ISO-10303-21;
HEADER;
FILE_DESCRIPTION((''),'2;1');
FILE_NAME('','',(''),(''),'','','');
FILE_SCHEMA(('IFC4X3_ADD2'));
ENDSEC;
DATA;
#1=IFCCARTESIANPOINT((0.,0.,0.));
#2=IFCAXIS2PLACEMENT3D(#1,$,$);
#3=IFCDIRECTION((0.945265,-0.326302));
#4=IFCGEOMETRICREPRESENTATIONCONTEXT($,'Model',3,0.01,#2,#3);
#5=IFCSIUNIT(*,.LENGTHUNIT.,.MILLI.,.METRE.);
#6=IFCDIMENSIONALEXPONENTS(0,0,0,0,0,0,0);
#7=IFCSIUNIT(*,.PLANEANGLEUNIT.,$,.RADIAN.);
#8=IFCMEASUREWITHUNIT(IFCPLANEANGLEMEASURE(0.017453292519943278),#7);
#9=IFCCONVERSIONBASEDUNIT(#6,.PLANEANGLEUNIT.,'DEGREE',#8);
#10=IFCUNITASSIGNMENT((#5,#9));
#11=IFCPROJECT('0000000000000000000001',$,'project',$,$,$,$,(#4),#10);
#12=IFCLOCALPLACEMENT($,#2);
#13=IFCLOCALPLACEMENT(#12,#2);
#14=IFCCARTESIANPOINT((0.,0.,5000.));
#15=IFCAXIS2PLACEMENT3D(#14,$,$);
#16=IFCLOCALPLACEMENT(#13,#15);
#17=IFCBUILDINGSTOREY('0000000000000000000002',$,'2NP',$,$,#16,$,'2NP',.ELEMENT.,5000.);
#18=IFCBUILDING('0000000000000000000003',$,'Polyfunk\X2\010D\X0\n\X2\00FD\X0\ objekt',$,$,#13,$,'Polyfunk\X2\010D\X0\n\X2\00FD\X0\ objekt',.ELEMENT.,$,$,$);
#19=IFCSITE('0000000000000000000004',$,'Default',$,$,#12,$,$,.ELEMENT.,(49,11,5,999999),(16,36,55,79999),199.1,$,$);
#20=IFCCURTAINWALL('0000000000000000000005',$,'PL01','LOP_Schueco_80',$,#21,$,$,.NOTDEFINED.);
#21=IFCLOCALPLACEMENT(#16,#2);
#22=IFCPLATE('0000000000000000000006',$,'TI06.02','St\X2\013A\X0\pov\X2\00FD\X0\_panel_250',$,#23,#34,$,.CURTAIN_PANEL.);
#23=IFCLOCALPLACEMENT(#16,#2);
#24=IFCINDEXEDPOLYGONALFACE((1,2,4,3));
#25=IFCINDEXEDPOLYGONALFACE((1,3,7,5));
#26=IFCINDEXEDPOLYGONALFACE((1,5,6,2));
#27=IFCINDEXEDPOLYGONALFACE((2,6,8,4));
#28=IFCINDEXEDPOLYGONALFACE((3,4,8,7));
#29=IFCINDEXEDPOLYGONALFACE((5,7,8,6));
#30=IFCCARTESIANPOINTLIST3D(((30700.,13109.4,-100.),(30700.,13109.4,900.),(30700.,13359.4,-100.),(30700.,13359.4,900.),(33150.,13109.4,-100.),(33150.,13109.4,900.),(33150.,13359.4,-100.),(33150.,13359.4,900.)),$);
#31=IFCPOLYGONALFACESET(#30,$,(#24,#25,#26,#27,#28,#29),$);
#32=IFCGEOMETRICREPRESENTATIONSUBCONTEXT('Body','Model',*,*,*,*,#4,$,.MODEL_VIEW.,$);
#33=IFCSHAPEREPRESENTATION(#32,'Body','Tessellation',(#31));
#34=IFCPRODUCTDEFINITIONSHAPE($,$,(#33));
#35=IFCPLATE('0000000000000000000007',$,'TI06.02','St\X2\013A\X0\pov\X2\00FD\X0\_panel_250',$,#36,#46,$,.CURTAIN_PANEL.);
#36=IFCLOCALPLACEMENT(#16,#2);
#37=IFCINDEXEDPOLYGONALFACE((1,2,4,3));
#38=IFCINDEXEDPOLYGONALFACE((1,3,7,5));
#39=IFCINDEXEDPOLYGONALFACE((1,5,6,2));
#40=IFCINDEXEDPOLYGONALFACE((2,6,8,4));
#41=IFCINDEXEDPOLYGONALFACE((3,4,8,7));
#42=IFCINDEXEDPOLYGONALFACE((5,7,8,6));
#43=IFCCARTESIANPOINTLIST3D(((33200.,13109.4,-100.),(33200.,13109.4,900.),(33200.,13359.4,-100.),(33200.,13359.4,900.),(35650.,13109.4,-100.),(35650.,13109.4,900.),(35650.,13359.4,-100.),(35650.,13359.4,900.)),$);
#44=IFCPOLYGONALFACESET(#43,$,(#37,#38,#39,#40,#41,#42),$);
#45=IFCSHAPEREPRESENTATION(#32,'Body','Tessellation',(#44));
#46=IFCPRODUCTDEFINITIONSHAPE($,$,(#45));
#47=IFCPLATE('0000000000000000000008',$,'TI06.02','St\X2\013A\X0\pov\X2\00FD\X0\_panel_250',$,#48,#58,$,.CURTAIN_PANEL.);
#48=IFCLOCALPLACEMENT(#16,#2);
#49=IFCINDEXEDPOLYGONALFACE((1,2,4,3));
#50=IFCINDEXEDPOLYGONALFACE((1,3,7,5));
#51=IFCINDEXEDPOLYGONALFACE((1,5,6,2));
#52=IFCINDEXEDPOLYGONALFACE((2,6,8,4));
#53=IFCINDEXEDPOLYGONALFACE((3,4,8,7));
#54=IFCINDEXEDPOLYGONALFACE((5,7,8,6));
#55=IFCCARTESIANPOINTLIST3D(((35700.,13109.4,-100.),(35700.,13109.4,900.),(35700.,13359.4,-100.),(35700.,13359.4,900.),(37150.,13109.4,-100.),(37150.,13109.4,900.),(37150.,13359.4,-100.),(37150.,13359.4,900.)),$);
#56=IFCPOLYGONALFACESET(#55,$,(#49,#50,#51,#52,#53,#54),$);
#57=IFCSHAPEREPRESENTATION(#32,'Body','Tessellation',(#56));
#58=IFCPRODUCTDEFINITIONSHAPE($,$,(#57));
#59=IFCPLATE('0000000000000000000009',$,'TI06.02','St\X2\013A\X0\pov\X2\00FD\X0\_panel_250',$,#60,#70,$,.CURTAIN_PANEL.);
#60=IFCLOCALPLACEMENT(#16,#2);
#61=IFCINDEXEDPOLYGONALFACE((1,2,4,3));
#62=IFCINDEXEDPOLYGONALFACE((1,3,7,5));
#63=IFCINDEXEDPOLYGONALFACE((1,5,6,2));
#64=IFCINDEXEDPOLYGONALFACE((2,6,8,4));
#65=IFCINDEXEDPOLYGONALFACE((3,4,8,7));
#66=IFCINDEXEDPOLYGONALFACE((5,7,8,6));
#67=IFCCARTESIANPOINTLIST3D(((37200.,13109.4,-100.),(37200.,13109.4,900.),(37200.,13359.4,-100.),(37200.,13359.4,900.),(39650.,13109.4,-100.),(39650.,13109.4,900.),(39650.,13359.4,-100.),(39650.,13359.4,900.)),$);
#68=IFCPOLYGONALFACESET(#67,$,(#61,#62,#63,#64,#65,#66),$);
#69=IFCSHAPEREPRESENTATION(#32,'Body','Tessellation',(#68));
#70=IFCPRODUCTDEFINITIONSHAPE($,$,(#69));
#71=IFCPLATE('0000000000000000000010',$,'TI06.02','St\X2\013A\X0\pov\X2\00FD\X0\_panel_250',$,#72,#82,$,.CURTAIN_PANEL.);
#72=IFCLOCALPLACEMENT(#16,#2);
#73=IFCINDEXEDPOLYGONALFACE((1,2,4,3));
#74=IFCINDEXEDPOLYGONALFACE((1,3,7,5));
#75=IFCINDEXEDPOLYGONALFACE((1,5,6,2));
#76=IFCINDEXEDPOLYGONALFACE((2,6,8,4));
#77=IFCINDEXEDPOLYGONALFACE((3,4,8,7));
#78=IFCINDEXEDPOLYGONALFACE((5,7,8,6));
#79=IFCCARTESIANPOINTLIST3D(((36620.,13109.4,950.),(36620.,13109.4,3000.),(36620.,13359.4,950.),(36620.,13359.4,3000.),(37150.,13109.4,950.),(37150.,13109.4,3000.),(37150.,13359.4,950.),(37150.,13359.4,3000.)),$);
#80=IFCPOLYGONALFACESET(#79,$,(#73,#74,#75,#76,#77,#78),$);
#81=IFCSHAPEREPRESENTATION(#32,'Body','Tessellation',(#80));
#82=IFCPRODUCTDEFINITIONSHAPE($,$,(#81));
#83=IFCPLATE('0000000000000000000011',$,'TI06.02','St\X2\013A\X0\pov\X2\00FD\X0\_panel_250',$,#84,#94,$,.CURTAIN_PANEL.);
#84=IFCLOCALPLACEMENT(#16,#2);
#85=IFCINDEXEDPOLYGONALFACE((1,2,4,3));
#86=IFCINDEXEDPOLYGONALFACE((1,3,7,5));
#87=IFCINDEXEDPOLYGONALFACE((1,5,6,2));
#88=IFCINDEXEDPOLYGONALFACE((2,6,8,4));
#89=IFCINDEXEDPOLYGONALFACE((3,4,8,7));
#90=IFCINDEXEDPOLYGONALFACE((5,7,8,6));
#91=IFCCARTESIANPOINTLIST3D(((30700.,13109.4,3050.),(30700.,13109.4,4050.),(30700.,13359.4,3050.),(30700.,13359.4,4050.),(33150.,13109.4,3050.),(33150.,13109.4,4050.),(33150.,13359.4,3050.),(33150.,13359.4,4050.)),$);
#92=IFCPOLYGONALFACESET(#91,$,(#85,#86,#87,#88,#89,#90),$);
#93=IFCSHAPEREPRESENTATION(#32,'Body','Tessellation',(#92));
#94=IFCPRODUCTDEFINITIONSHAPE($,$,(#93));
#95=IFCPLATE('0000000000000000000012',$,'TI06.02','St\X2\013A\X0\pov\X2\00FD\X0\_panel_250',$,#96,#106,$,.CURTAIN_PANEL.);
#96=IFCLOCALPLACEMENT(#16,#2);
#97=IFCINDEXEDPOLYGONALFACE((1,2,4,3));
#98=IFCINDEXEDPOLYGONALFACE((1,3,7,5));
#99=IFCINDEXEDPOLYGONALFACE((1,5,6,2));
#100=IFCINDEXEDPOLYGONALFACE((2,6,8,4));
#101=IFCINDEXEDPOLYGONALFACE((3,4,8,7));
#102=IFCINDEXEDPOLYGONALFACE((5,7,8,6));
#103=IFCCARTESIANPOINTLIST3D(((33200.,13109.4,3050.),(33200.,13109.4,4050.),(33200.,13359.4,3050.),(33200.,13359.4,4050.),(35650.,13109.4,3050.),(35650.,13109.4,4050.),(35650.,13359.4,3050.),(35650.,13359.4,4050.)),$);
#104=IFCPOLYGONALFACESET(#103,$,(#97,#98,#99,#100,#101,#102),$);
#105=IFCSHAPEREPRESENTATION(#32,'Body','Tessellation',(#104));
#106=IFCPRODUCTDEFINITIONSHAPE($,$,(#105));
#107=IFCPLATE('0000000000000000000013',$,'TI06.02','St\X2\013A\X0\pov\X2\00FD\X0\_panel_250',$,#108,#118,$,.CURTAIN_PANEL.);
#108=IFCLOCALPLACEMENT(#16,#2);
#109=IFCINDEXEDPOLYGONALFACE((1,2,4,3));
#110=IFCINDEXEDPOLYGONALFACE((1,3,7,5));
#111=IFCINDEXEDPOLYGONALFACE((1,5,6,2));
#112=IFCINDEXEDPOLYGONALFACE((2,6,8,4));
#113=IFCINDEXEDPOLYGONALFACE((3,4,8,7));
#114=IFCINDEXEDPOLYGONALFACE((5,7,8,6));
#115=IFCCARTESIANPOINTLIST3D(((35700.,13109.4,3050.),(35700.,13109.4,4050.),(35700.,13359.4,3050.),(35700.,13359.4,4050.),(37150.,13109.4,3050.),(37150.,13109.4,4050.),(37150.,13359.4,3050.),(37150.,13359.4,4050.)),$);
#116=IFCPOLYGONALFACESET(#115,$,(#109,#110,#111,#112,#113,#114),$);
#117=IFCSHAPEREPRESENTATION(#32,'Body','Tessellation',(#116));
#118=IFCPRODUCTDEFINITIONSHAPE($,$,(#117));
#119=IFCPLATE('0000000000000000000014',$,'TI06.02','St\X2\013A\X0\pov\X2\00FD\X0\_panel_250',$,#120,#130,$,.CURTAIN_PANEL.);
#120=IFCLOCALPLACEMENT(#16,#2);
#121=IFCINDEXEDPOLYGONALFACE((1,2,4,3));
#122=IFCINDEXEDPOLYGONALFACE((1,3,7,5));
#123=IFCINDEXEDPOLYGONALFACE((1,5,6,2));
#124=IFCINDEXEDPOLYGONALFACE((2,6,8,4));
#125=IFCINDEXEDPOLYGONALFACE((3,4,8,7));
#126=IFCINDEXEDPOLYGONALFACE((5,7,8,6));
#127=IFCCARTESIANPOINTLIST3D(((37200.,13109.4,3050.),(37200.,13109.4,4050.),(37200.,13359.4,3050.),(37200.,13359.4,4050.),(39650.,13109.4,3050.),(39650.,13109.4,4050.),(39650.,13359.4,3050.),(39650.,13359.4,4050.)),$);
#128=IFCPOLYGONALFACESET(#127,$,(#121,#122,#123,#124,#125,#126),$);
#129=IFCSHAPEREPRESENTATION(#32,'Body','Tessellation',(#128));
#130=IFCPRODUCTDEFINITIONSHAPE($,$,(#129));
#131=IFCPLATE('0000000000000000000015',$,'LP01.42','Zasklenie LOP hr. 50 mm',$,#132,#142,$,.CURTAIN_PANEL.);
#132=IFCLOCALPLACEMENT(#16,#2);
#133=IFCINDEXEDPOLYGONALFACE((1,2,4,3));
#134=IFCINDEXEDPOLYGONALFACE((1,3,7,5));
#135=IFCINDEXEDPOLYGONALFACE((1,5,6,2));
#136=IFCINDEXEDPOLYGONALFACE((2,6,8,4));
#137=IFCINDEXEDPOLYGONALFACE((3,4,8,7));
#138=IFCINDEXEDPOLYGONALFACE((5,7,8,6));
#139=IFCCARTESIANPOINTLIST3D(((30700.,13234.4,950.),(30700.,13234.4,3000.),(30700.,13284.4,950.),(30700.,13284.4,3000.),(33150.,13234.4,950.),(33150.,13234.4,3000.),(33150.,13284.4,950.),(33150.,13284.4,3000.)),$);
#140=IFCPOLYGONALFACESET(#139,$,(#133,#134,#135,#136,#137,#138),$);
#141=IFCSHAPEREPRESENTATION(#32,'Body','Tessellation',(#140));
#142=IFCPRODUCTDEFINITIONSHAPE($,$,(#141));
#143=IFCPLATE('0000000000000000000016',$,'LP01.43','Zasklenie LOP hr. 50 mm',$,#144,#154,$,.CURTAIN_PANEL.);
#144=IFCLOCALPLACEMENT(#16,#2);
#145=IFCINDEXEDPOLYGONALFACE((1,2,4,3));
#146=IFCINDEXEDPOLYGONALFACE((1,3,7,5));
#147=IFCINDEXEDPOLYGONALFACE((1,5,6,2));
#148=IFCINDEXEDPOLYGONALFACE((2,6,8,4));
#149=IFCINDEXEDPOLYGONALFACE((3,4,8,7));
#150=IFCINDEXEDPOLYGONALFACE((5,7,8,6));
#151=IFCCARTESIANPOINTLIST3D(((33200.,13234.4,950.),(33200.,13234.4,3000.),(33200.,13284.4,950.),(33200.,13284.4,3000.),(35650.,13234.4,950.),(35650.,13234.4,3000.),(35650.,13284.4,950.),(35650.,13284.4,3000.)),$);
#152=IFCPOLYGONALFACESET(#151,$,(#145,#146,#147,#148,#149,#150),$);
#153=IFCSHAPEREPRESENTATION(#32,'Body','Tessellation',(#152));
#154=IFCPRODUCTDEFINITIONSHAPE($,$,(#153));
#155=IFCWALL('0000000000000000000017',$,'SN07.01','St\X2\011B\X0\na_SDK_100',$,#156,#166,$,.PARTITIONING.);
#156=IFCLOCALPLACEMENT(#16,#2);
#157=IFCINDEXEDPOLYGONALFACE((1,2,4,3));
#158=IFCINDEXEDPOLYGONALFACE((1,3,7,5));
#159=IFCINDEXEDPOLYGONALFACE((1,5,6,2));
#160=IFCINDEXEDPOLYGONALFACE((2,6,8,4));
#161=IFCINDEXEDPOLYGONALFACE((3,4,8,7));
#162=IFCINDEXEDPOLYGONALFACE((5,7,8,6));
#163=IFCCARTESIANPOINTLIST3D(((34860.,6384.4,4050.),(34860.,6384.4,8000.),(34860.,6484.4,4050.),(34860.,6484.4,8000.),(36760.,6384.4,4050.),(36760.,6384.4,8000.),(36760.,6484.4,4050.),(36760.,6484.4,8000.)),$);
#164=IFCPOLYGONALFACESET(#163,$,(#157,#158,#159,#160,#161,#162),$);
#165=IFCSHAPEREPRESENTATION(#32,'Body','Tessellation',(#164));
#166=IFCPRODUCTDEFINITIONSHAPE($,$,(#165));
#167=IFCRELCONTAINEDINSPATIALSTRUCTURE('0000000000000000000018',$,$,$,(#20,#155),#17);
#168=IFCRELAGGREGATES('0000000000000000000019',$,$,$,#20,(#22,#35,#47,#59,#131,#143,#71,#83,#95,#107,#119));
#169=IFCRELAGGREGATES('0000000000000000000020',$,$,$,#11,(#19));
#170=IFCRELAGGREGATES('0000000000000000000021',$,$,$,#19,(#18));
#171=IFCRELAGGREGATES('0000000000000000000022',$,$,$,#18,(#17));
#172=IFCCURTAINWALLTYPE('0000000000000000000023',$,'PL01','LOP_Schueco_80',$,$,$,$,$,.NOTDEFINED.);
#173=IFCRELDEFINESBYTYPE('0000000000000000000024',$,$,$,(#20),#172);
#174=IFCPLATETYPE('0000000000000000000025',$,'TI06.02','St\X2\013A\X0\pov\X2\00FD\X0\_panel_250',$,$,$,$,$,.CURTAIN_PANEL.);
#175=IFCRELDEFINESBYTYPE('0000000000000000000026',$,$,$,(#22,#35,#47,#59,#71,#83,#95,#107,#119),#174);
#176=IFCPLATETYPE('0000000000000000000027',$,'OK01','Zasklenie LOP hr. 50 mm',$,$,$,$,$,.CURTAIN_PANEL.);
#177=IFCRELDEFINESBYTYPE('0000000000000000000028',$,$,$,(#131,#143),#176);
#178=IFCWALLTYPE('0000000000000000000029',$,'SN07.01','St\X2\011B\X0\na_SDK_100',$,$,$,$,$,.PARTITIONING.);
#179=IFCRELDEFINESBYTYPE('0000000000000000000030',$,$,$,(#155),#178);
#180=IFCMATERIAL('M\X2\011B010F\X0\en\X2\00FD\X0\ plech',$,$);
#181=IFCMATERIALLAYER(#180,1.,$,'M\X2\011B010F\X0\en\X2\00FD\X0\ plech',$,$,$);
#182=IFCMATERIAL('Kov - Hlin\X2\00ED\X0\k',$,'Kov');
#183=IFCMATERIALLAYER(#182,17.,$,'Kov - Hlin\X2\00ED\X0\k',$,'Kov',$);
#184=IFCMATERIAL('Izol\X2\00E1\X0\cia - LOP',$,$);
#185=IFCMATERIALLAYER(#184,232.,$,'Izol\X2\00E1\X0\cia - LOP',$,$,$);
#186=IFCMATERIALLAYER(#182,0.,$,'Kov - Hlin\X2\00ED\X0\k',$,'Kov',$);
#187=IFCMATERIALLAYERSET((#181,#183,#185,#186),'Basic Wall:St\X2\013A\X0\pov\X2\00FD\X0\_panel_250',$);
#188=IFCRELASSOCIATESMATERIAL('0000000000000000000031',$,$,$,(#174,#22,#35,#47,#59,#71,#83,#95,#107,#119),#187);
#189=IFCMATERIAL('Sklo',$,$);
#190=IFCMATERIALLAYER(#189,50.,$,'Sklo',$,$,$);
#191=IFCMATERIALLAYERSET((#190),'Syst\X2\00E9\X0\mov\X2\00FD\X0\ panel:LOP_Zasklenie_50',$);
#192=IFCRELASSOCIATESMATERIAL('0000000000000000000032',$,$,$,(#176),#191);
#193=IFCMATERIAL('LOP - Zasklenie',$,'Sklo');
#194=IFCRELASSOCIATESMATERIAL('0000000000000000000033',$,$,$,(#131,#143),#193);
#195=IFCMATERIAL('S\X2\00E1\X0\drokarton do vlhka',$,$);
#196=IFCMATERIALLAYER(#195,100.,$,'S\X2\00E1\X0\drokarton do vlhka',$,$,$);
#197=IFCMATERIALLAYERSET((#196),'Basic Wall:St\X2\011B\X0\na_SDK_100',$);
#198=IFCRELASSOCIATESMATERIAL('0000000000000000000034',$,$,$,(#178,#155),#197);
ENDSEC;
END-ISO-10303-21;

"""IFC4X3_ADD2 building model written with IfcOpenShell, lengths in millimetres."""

from ifc_helpers import new_model, entity, si_unit, converted_unit, direction, frame, frame_2d, origin, origin_2d_with_axis, place, context, subcontext, project, spatial, polyline, rectangle, extrude, clip, bounded_halfspace, source, transform, mapped, material, layer, layer_set, layer_usage, type_object, type_shapes, element, aggregate, save


model = new_model("IFC4X3_ADD2")

# Units and contexts
model_context = context("Model", 3, precision=0.01, world=origin(), true_north=direction((0.945265, -0.326302)))
body_context = subcontext(model_context, "Body", "Model", "MODEL_VIEW")
ifc_project = project(units=[si_unit("LENGTHUNIT", "METRE", prefix="MILLI"), converted_unit("PLANEANGLEUNIT", "DEGREE", entity("IfcPlaneAngleMeasure", 0.017453292519943278), si_unit("PLANEANGLEUNIT", "RADIAN"), dimensions=[0, 0, 0, 0, 0, 0, 0])], contexts=[model_context])

# Site, building, storey
site_placement = place(None, origin())
site = spatial("IfcSite", under=ifc_project, at=site_placement, Name="Default", CompositionType="ELEMENT", RefLatitude=(49, 11, 5, 999999), RefLongitude=(16, 36, 55, 79999), RefElevation=199.1)
building_placement = place(site_placement, origin())
building = spatial("IfcBuilding", under=site, at=building_placement, Name="Polyfunkčný objekt", LongName="Polyfunkčný objekt", CompositionType="ELEMENT")
storey_placement = place(building_placement, frame((0.0, 0.0, 5000.0)))
storey = spatial("IfcBuildingStorey", under=building, at=storey_placement, Name="2NP", LongName="2NP", CompositionType="ELEMENT", Elevation=5000.0)

# Curtain wall, plates
curtain_wall_type = type_object("IfcCurtainWallType", Name="PL01", Description="LOP_Schueco_80", PredefinedType="NOTDEFINED")
curtain_wall_placement = place(storey_placement, frame((0.0, 0.0, -5000.0)))
curtain_wall = element("IfcCurtainWall", 1, at=curtain_wall_placement, inside=storey, type_object=curtain_wall_type, Name="PL01", Description="LOP_Schueco_80", PredefinedType="NOTDEFINED")
ifc_material_1 = material(Name="Měďený plech")
ifc_layer_1 = layer(ifc_material_1, 1.0, Name="Měďený plech")
ifc_material_2 = material(Name="Kov - Hliník", Category="Kov")
ifc_layer_2 = layer(ifc_material_2, 17.0, Name="Kov - Hliník", Category="Kov")
ifc_material_3 = material(Name="Izolácia - LOP")
ifc_layer_3 = layer(ifc_material_3, 232.0, Name="Izolácia - LOP")
ifc_layer_4 = layer(ifc_material_2, 0.0, Name="Kov - Hliník", Category="Kov")
ifc_layer_set_1 = layer_set([ifc_layer_1, ifc_layer_2, ifc_layer_3, ifc_layer_4], Name="Basic Wall:Stĺpový_panel_250")
ifc_layer_usage_1 = layer_usage(ifc_layer_set_1, "AXIS2", "NEGATIVE", 125.0)
plate_type_1 = type_object("IfcPlateType", Name="TI06.02", Description="Stĺpový_panel_250", PredefinedType="CURTAIN_PANEL", material=ifc_layer_set_1)
plate_1_placement = place(storey_placement, frame((30700.0, 13234.4, -100.0)))
plate_1 = element("IfcPlate", 2, at=plate_1_placement, type_object=plate_type_1, material=ifc_layer_usage_1, Name="TI06.02", Description="Stĺpový_panel_250", PredefinedType="CURTAIN_PANEL", context=body_context, shape_type="SweptSolid", body=[
    extrude(rectangle(XDim=250.0, YDim=2450.0, at=frame_2d((0.0, 0.0), x_axis=(1.0, 0.0))), frame((1225.0, 0.0, 0.0), z_axis=(0.0, 0.0, 1.0), x_axis=(0.0, 1.0, 0.0)), (0.0, 0.0, 1.0), 1000.0),
])
ifc_layer_usage_2 = layer_usage(ifc_layer_set_1, "AXIS2", "NEGATIVE", 125.0)
plate_2_placement = place(storey_placement, frame((33200.0, 13234.4, -100.0)))
plate_2 = element("IfcPlate", 3, at=plate_2_placement, type_object=plate_type_1, material=ifc_layer_usage_2, Name="TI06.02", Description="Stĺpový_panel_250", PredefinedType="CURTAIN_PANEL", context=body_context, shape_type="SweptSolid", body=[
    extrude(rectangle(XDim=250.0, YDim=2450.0, at=frame_2d((0.0, 0.0), x_axis=(1.0, 0.0))), frame((1225.0, 0.0, 0.0), z_axis=(0.0, 0.0, 1.0), x_axis=(0.0, 1.0, 0.0)), (0.0, 0.0, 1.0), 1000.0),
])
ifc_layer_usage_3 = layer_usage(ifc_layer_set_1, "AXIS2", "NEGATIVE", 125.0)
plate_3_placement = place(storey_placement, frame((35700.0, 13234.4, -100.0)))
plate_3 = element("IfcPlate", 4, at=plate_3_placement, type_object=plate_type_1, material=ifc_layer_usage_3, Name="TI06.02", Description="Stĺpový_panel_250", PredefinedType="CURTAIN_PANEL", context=body_context, shape_type="SweptSolid", body=[
    extrude(rectangle(XDim=250.0, YDim=1450.0, at=origin_2d_with_axis()), frame((725.0, 0.0, 0.0), z_axis=(0.0, 0.0, 1.0), x_axis=(0.0, 1.0, 0.0)), (0.0, 0.0, 1.0), 1000.0),
])
ifc_layer_usage_4 = layer_usage(ifc_layer_set_1, "AXIS2", "NEGATIVE", 125.0)
plate_4_placement = place(storey_placement, frame((37200.0, 13234.4, -100.0)))
plate_4 = element("IfcPlate", 5, at=plate_4_placement, type_object=plate_type_1, material=ifc_layer_usage_4, Name="TI06.02", Description="Stĺpový_panel_250", PredefinedType="CURTAIN_PANEL", context=body_context, shape_type="SweptSolid", body=[
    extrude(rectangle(XDim=250.0, YDim=2450.0, at=frame_2d((0.0, 0.0), x_axis=(1.0, 0.0))), frame((1225.0, 0.0, 0.0), z_axis=(0.0, 0.0, 1.0), x_axis=(0.0, 1.0, 0.0)), (0.0, 0.0, 1.0), 1000.0),
])
ifc_layer_usage_5 = layer_usage(ifc_layer_set_1, "AXIS2", "NEGATIVE", 125.0)
plate_5_placement = place(storey_placement, frame((36620.0, 13234.4, 950.0)))
plate_5 = element("IfcPlate", 6, at=plate_5_placement, type_object=plate_type_1, material=ifc_layer_usage_5, Name="TI06.02", Description="Stĺpový_panel_250", PredefinedType="CURTAIN_PANEL", context=body_context, shape_type="SweptSolid", body=[
    extrude(rectangle(XDim=250.0, YDim=530.0, at=frame_2d((0.0, 0.0), x_axis=(1.0, 0.0))), frame((265.0, 0.0, 0.0), z_axis=(0.0, 0.0, 1.0), x_axis=(0.0, 1.0, 0.0)), (0.0, 0.0, 1.0), 2050.0),
])
ifc_layer_usage_6 = layer_usage(ifc_layer_set_1, "AXIS2", "NEGATIVE", 125.0)
plate_6_placement = place(storey_placement, frame((30700.0, 13234.4, 3050.0)))
plate_6 = element("IfcPlate", 7, at=plate_6_placement, type_object=plate_type_1, material=ifc_layer_usage_6, Name="TI06.02", Description="Stĺpový_panel_250", PredefinedType="CURTAIN_PANEL", context=body_context, shape_type="SweptSolid", body=[
    extrude(rectangle(XDim=250.0, YDim=2450.0, at=frame_2d((0.0, 0.0), x_axis=(1.0, 0.0))), frame((1225.0, 0.0, 0.0), z_axis=(0.0, 0.0, 1.0), x_axis=(0.0, 1.0, 0.0)), (0.0, 0.0, 1.0), 1000.0),
])
ifc_layer_usage_7 = layer_usage(ifc_layer_set_1, "AXIS2", "NEGATIVE", 125.0)
plate_7_placement = place(storey_placement, frame((33200.0, 13234.4, 3050.0)))
plate_7 = element("IfcPlate", 8, at=plate_7_placement, type_object=plate_type_1, material=ifc_layer_usage_7, Name="TI06.02", Description="Stĺpový_panel_250", PredefinedType="CURTAIN_PANEL", context=body_context, shape_type="SweptSolid", body=[
    extrude(rectangle(XDim=250.0, YDim=2450.0, at=frame_2d((0.0, 0.0), x_axis=(1.0, 0.0))), frame((1225.0, 0.0, 0.0), z_axis=(0.0, 0.0, 1.0), x_axis=(0.0, 1.0, 0.0)), (0.0, 0.0, 1.0), 1000.0),
])
ifc_layer_usage_8 = layer_usage(ifc_layer_set_1, "AXIS2", "NEGATIVE", 125.0)
plate_8_placement = place(storey_placement, frame((35700.0, 13234.4, 3050.0)))
plate_8 = element("IfcPlate", 9, at=plate_8_placement, type_object=plate_type_1, material=ifc_layer_usage_8, Name="TI06.02", Description="Stĺpový_panel_250", PredefinedType="CURTAIN_PANEL", context=body_context, shape_type="SweptSolid", body=[
    extrude(rectangle(XDim=250.0, YDim=1450.0, at=origin_2d_with_axis()), frame((725.0, 0.0, 0.0), z_axis=(0.0, 0.0, 1.0), x_axis=(0.0, 1.0, 0.0)), (0.0, 0.0, 1.0), 1000.0),
])
ifc_layer_usage_9 = layer_usage(ifc_layer_set_1, "AXIS2", "NEGATIVE", 125.0)
plate_9_placement = place(storey_placement, frame((37200.0, 13234.4, 3050.0)))
plate_9 = element("IfcPlate", 10, at=plate_9_placement, type_object=plate_type_1, material=ifc_layer_usage_9, Name="TI06.02", Description="Stĺpový_panel_250", PredefinedType="CURTAIN_PANEL", context=body_context, shape_type="SweptSolid", body=[
    extrude(rectangle(XDim=250.0, YDim=2450.0, at=frame_2d((0.0, 0.0), x_axis=(1.0, 0.0))), frame((1225.0, 0.0, 0.0), z_axis=(0.0, 0.0, 1.0), x_axis=(0.0, 1.0, 0.0)), (0.0, 0.0, 1.0), 1000.0),
])
ifc_material_4 = material(Name="LOP - Zasklenie", Category="Sklo")
ifc_material_5 = material(Name="Sklo")
ifc_layer_5 = layer(ifc_material_5, 50.0, Name="Sklo")
ifc_layer_set_2 = layer_set([ifc_layer_5], Name="Systémový panel:LOP_Zasklenie_50")
plate_type_2 = type_object("IfcPlateType", Name="OK01", Description="Zasklenie LOP hr. 50 mm", PredefinedType="CURTAIN_PANEL", material=ifc_layer_set_2)
shared_shape_1 = source(origin(), body_context, "Body", "SweptSolid", [
    extrude(rectangle(XDim=50.0, YDim=2450.0, at=origin_2d_with_axis()), frame((0.0, 25.0, 0.0), z_axis=(0.0, 0.0, 1.0), x_axis=(0.0, 1.0, 0.0)), (0.0, 0.0, 1.0), 2050.0),
])
type_shapes(plate_type_2, [shared_shape_1])
plate_10_placement = place(curtain_wall_placement, frame((31925.0, 13234.4, 5950.0)))
plate_10 = element("IfcPlate", 11, at=plate_10_placement, type_object=plate_type_2, material=ifc_material_4, Name="LP01.42", Description="Zasklenie LOP hr. 50 mm", PredefinedType="CURTAIN_PANEL", context=body_context, shape_type="MappedRepresentation", body=[
    mapped(shared_shape_1, transform((0.0, 0.0, 0.0), scale=1.0)),
])
plate_11_placement = place(curtain_wall_placement, frame((34425.0, 13234.4, 5950.0)))
plate_11 = element("IfcPlate", 12, at=plate_11_placement, type_object=plate_type_2, material=ifc_material_4, Name="LP01.43", Description="Zasklenie LOP hr. 50 mm", PredefinedType="CURTAIN_PANEL", context=body_context, shape_type="MappedRepresentation", body=[
    mapped(shared_shape_1, transform((0.0, 0.0, 0.0), scale=1.0)),
])

# Wall
ifc_material_6 = material(Name="Sádrokarton do vlhka")
ifc_layer_6 = layer(ifc_material_6, 100.0, Name="Sádrokarton do vlhka")
ifc_layer_set_3 = layer_set([ifc_layer_6], Name="Basic Wall:Stěna_SDK_100")
wall_type_1 = type_object("IfcWallType", Name="SN07.01", Description="Stěna_SDK_100", PredefinedType="PARTITIONING", material=ifc_layer_set_3)
wall_1_placement = place(storey_placement, frame((36760.0, 6434.4, 4050.0), z_axis=(0.0, 0.0, 1.0), x_axis=(-1.0, 0.0, 0.0)))
element("IfcWall", 13, at=wall_1_placement, inside=storey, type_object=wall_type_1, material=ifc_layer_set_3, Name="SN07.01", Description="Stěna_SDK_100", PredefinedType="PARTITIONING", context=body_context, shape_type="Clipping", body=[
    clip(clip(extrude(rectangle(XDim=1900.0, YDim=100.0, at=frame_2d((950.0, 0.0), x_axis=(-1.0, 0.0))), origin(), (0.0, 0.0, 1.0), 3950.0), bounded_halfspace(frame((1900.0, -50.0, 0.0)), True, frame((1900.0, -50.0, 0.0)), polyline([(0.0, 0.0), (0.0, 100.0), (-1750.0, 100.0), (-1900.0, 100.0), (-1900.0, 0.0), (0.0, 0.0)]))), bounded_halfspace(frame((0.0, -50.0, 3950.0), z_axis=(0.0, 0.0, -1.0), x_axis=(-1.0, 0.0, 0.0)), True, frame((0.0, -50.0, 3950.0)), polyline([(0.0, 0.0), (1900.0, 0.0), (1900.0, 100.0), (150.0, 100.0), (0.0, 100.0), (0.0, 0.0)]))),
])

aggregate(curtain_wall, [plate_1, plate_2, plate_3, plate_4, plate_10, plate_11, plate_5, plate_6, plate_7, plate_8, plate_9])

save(model, "model.ifc")
